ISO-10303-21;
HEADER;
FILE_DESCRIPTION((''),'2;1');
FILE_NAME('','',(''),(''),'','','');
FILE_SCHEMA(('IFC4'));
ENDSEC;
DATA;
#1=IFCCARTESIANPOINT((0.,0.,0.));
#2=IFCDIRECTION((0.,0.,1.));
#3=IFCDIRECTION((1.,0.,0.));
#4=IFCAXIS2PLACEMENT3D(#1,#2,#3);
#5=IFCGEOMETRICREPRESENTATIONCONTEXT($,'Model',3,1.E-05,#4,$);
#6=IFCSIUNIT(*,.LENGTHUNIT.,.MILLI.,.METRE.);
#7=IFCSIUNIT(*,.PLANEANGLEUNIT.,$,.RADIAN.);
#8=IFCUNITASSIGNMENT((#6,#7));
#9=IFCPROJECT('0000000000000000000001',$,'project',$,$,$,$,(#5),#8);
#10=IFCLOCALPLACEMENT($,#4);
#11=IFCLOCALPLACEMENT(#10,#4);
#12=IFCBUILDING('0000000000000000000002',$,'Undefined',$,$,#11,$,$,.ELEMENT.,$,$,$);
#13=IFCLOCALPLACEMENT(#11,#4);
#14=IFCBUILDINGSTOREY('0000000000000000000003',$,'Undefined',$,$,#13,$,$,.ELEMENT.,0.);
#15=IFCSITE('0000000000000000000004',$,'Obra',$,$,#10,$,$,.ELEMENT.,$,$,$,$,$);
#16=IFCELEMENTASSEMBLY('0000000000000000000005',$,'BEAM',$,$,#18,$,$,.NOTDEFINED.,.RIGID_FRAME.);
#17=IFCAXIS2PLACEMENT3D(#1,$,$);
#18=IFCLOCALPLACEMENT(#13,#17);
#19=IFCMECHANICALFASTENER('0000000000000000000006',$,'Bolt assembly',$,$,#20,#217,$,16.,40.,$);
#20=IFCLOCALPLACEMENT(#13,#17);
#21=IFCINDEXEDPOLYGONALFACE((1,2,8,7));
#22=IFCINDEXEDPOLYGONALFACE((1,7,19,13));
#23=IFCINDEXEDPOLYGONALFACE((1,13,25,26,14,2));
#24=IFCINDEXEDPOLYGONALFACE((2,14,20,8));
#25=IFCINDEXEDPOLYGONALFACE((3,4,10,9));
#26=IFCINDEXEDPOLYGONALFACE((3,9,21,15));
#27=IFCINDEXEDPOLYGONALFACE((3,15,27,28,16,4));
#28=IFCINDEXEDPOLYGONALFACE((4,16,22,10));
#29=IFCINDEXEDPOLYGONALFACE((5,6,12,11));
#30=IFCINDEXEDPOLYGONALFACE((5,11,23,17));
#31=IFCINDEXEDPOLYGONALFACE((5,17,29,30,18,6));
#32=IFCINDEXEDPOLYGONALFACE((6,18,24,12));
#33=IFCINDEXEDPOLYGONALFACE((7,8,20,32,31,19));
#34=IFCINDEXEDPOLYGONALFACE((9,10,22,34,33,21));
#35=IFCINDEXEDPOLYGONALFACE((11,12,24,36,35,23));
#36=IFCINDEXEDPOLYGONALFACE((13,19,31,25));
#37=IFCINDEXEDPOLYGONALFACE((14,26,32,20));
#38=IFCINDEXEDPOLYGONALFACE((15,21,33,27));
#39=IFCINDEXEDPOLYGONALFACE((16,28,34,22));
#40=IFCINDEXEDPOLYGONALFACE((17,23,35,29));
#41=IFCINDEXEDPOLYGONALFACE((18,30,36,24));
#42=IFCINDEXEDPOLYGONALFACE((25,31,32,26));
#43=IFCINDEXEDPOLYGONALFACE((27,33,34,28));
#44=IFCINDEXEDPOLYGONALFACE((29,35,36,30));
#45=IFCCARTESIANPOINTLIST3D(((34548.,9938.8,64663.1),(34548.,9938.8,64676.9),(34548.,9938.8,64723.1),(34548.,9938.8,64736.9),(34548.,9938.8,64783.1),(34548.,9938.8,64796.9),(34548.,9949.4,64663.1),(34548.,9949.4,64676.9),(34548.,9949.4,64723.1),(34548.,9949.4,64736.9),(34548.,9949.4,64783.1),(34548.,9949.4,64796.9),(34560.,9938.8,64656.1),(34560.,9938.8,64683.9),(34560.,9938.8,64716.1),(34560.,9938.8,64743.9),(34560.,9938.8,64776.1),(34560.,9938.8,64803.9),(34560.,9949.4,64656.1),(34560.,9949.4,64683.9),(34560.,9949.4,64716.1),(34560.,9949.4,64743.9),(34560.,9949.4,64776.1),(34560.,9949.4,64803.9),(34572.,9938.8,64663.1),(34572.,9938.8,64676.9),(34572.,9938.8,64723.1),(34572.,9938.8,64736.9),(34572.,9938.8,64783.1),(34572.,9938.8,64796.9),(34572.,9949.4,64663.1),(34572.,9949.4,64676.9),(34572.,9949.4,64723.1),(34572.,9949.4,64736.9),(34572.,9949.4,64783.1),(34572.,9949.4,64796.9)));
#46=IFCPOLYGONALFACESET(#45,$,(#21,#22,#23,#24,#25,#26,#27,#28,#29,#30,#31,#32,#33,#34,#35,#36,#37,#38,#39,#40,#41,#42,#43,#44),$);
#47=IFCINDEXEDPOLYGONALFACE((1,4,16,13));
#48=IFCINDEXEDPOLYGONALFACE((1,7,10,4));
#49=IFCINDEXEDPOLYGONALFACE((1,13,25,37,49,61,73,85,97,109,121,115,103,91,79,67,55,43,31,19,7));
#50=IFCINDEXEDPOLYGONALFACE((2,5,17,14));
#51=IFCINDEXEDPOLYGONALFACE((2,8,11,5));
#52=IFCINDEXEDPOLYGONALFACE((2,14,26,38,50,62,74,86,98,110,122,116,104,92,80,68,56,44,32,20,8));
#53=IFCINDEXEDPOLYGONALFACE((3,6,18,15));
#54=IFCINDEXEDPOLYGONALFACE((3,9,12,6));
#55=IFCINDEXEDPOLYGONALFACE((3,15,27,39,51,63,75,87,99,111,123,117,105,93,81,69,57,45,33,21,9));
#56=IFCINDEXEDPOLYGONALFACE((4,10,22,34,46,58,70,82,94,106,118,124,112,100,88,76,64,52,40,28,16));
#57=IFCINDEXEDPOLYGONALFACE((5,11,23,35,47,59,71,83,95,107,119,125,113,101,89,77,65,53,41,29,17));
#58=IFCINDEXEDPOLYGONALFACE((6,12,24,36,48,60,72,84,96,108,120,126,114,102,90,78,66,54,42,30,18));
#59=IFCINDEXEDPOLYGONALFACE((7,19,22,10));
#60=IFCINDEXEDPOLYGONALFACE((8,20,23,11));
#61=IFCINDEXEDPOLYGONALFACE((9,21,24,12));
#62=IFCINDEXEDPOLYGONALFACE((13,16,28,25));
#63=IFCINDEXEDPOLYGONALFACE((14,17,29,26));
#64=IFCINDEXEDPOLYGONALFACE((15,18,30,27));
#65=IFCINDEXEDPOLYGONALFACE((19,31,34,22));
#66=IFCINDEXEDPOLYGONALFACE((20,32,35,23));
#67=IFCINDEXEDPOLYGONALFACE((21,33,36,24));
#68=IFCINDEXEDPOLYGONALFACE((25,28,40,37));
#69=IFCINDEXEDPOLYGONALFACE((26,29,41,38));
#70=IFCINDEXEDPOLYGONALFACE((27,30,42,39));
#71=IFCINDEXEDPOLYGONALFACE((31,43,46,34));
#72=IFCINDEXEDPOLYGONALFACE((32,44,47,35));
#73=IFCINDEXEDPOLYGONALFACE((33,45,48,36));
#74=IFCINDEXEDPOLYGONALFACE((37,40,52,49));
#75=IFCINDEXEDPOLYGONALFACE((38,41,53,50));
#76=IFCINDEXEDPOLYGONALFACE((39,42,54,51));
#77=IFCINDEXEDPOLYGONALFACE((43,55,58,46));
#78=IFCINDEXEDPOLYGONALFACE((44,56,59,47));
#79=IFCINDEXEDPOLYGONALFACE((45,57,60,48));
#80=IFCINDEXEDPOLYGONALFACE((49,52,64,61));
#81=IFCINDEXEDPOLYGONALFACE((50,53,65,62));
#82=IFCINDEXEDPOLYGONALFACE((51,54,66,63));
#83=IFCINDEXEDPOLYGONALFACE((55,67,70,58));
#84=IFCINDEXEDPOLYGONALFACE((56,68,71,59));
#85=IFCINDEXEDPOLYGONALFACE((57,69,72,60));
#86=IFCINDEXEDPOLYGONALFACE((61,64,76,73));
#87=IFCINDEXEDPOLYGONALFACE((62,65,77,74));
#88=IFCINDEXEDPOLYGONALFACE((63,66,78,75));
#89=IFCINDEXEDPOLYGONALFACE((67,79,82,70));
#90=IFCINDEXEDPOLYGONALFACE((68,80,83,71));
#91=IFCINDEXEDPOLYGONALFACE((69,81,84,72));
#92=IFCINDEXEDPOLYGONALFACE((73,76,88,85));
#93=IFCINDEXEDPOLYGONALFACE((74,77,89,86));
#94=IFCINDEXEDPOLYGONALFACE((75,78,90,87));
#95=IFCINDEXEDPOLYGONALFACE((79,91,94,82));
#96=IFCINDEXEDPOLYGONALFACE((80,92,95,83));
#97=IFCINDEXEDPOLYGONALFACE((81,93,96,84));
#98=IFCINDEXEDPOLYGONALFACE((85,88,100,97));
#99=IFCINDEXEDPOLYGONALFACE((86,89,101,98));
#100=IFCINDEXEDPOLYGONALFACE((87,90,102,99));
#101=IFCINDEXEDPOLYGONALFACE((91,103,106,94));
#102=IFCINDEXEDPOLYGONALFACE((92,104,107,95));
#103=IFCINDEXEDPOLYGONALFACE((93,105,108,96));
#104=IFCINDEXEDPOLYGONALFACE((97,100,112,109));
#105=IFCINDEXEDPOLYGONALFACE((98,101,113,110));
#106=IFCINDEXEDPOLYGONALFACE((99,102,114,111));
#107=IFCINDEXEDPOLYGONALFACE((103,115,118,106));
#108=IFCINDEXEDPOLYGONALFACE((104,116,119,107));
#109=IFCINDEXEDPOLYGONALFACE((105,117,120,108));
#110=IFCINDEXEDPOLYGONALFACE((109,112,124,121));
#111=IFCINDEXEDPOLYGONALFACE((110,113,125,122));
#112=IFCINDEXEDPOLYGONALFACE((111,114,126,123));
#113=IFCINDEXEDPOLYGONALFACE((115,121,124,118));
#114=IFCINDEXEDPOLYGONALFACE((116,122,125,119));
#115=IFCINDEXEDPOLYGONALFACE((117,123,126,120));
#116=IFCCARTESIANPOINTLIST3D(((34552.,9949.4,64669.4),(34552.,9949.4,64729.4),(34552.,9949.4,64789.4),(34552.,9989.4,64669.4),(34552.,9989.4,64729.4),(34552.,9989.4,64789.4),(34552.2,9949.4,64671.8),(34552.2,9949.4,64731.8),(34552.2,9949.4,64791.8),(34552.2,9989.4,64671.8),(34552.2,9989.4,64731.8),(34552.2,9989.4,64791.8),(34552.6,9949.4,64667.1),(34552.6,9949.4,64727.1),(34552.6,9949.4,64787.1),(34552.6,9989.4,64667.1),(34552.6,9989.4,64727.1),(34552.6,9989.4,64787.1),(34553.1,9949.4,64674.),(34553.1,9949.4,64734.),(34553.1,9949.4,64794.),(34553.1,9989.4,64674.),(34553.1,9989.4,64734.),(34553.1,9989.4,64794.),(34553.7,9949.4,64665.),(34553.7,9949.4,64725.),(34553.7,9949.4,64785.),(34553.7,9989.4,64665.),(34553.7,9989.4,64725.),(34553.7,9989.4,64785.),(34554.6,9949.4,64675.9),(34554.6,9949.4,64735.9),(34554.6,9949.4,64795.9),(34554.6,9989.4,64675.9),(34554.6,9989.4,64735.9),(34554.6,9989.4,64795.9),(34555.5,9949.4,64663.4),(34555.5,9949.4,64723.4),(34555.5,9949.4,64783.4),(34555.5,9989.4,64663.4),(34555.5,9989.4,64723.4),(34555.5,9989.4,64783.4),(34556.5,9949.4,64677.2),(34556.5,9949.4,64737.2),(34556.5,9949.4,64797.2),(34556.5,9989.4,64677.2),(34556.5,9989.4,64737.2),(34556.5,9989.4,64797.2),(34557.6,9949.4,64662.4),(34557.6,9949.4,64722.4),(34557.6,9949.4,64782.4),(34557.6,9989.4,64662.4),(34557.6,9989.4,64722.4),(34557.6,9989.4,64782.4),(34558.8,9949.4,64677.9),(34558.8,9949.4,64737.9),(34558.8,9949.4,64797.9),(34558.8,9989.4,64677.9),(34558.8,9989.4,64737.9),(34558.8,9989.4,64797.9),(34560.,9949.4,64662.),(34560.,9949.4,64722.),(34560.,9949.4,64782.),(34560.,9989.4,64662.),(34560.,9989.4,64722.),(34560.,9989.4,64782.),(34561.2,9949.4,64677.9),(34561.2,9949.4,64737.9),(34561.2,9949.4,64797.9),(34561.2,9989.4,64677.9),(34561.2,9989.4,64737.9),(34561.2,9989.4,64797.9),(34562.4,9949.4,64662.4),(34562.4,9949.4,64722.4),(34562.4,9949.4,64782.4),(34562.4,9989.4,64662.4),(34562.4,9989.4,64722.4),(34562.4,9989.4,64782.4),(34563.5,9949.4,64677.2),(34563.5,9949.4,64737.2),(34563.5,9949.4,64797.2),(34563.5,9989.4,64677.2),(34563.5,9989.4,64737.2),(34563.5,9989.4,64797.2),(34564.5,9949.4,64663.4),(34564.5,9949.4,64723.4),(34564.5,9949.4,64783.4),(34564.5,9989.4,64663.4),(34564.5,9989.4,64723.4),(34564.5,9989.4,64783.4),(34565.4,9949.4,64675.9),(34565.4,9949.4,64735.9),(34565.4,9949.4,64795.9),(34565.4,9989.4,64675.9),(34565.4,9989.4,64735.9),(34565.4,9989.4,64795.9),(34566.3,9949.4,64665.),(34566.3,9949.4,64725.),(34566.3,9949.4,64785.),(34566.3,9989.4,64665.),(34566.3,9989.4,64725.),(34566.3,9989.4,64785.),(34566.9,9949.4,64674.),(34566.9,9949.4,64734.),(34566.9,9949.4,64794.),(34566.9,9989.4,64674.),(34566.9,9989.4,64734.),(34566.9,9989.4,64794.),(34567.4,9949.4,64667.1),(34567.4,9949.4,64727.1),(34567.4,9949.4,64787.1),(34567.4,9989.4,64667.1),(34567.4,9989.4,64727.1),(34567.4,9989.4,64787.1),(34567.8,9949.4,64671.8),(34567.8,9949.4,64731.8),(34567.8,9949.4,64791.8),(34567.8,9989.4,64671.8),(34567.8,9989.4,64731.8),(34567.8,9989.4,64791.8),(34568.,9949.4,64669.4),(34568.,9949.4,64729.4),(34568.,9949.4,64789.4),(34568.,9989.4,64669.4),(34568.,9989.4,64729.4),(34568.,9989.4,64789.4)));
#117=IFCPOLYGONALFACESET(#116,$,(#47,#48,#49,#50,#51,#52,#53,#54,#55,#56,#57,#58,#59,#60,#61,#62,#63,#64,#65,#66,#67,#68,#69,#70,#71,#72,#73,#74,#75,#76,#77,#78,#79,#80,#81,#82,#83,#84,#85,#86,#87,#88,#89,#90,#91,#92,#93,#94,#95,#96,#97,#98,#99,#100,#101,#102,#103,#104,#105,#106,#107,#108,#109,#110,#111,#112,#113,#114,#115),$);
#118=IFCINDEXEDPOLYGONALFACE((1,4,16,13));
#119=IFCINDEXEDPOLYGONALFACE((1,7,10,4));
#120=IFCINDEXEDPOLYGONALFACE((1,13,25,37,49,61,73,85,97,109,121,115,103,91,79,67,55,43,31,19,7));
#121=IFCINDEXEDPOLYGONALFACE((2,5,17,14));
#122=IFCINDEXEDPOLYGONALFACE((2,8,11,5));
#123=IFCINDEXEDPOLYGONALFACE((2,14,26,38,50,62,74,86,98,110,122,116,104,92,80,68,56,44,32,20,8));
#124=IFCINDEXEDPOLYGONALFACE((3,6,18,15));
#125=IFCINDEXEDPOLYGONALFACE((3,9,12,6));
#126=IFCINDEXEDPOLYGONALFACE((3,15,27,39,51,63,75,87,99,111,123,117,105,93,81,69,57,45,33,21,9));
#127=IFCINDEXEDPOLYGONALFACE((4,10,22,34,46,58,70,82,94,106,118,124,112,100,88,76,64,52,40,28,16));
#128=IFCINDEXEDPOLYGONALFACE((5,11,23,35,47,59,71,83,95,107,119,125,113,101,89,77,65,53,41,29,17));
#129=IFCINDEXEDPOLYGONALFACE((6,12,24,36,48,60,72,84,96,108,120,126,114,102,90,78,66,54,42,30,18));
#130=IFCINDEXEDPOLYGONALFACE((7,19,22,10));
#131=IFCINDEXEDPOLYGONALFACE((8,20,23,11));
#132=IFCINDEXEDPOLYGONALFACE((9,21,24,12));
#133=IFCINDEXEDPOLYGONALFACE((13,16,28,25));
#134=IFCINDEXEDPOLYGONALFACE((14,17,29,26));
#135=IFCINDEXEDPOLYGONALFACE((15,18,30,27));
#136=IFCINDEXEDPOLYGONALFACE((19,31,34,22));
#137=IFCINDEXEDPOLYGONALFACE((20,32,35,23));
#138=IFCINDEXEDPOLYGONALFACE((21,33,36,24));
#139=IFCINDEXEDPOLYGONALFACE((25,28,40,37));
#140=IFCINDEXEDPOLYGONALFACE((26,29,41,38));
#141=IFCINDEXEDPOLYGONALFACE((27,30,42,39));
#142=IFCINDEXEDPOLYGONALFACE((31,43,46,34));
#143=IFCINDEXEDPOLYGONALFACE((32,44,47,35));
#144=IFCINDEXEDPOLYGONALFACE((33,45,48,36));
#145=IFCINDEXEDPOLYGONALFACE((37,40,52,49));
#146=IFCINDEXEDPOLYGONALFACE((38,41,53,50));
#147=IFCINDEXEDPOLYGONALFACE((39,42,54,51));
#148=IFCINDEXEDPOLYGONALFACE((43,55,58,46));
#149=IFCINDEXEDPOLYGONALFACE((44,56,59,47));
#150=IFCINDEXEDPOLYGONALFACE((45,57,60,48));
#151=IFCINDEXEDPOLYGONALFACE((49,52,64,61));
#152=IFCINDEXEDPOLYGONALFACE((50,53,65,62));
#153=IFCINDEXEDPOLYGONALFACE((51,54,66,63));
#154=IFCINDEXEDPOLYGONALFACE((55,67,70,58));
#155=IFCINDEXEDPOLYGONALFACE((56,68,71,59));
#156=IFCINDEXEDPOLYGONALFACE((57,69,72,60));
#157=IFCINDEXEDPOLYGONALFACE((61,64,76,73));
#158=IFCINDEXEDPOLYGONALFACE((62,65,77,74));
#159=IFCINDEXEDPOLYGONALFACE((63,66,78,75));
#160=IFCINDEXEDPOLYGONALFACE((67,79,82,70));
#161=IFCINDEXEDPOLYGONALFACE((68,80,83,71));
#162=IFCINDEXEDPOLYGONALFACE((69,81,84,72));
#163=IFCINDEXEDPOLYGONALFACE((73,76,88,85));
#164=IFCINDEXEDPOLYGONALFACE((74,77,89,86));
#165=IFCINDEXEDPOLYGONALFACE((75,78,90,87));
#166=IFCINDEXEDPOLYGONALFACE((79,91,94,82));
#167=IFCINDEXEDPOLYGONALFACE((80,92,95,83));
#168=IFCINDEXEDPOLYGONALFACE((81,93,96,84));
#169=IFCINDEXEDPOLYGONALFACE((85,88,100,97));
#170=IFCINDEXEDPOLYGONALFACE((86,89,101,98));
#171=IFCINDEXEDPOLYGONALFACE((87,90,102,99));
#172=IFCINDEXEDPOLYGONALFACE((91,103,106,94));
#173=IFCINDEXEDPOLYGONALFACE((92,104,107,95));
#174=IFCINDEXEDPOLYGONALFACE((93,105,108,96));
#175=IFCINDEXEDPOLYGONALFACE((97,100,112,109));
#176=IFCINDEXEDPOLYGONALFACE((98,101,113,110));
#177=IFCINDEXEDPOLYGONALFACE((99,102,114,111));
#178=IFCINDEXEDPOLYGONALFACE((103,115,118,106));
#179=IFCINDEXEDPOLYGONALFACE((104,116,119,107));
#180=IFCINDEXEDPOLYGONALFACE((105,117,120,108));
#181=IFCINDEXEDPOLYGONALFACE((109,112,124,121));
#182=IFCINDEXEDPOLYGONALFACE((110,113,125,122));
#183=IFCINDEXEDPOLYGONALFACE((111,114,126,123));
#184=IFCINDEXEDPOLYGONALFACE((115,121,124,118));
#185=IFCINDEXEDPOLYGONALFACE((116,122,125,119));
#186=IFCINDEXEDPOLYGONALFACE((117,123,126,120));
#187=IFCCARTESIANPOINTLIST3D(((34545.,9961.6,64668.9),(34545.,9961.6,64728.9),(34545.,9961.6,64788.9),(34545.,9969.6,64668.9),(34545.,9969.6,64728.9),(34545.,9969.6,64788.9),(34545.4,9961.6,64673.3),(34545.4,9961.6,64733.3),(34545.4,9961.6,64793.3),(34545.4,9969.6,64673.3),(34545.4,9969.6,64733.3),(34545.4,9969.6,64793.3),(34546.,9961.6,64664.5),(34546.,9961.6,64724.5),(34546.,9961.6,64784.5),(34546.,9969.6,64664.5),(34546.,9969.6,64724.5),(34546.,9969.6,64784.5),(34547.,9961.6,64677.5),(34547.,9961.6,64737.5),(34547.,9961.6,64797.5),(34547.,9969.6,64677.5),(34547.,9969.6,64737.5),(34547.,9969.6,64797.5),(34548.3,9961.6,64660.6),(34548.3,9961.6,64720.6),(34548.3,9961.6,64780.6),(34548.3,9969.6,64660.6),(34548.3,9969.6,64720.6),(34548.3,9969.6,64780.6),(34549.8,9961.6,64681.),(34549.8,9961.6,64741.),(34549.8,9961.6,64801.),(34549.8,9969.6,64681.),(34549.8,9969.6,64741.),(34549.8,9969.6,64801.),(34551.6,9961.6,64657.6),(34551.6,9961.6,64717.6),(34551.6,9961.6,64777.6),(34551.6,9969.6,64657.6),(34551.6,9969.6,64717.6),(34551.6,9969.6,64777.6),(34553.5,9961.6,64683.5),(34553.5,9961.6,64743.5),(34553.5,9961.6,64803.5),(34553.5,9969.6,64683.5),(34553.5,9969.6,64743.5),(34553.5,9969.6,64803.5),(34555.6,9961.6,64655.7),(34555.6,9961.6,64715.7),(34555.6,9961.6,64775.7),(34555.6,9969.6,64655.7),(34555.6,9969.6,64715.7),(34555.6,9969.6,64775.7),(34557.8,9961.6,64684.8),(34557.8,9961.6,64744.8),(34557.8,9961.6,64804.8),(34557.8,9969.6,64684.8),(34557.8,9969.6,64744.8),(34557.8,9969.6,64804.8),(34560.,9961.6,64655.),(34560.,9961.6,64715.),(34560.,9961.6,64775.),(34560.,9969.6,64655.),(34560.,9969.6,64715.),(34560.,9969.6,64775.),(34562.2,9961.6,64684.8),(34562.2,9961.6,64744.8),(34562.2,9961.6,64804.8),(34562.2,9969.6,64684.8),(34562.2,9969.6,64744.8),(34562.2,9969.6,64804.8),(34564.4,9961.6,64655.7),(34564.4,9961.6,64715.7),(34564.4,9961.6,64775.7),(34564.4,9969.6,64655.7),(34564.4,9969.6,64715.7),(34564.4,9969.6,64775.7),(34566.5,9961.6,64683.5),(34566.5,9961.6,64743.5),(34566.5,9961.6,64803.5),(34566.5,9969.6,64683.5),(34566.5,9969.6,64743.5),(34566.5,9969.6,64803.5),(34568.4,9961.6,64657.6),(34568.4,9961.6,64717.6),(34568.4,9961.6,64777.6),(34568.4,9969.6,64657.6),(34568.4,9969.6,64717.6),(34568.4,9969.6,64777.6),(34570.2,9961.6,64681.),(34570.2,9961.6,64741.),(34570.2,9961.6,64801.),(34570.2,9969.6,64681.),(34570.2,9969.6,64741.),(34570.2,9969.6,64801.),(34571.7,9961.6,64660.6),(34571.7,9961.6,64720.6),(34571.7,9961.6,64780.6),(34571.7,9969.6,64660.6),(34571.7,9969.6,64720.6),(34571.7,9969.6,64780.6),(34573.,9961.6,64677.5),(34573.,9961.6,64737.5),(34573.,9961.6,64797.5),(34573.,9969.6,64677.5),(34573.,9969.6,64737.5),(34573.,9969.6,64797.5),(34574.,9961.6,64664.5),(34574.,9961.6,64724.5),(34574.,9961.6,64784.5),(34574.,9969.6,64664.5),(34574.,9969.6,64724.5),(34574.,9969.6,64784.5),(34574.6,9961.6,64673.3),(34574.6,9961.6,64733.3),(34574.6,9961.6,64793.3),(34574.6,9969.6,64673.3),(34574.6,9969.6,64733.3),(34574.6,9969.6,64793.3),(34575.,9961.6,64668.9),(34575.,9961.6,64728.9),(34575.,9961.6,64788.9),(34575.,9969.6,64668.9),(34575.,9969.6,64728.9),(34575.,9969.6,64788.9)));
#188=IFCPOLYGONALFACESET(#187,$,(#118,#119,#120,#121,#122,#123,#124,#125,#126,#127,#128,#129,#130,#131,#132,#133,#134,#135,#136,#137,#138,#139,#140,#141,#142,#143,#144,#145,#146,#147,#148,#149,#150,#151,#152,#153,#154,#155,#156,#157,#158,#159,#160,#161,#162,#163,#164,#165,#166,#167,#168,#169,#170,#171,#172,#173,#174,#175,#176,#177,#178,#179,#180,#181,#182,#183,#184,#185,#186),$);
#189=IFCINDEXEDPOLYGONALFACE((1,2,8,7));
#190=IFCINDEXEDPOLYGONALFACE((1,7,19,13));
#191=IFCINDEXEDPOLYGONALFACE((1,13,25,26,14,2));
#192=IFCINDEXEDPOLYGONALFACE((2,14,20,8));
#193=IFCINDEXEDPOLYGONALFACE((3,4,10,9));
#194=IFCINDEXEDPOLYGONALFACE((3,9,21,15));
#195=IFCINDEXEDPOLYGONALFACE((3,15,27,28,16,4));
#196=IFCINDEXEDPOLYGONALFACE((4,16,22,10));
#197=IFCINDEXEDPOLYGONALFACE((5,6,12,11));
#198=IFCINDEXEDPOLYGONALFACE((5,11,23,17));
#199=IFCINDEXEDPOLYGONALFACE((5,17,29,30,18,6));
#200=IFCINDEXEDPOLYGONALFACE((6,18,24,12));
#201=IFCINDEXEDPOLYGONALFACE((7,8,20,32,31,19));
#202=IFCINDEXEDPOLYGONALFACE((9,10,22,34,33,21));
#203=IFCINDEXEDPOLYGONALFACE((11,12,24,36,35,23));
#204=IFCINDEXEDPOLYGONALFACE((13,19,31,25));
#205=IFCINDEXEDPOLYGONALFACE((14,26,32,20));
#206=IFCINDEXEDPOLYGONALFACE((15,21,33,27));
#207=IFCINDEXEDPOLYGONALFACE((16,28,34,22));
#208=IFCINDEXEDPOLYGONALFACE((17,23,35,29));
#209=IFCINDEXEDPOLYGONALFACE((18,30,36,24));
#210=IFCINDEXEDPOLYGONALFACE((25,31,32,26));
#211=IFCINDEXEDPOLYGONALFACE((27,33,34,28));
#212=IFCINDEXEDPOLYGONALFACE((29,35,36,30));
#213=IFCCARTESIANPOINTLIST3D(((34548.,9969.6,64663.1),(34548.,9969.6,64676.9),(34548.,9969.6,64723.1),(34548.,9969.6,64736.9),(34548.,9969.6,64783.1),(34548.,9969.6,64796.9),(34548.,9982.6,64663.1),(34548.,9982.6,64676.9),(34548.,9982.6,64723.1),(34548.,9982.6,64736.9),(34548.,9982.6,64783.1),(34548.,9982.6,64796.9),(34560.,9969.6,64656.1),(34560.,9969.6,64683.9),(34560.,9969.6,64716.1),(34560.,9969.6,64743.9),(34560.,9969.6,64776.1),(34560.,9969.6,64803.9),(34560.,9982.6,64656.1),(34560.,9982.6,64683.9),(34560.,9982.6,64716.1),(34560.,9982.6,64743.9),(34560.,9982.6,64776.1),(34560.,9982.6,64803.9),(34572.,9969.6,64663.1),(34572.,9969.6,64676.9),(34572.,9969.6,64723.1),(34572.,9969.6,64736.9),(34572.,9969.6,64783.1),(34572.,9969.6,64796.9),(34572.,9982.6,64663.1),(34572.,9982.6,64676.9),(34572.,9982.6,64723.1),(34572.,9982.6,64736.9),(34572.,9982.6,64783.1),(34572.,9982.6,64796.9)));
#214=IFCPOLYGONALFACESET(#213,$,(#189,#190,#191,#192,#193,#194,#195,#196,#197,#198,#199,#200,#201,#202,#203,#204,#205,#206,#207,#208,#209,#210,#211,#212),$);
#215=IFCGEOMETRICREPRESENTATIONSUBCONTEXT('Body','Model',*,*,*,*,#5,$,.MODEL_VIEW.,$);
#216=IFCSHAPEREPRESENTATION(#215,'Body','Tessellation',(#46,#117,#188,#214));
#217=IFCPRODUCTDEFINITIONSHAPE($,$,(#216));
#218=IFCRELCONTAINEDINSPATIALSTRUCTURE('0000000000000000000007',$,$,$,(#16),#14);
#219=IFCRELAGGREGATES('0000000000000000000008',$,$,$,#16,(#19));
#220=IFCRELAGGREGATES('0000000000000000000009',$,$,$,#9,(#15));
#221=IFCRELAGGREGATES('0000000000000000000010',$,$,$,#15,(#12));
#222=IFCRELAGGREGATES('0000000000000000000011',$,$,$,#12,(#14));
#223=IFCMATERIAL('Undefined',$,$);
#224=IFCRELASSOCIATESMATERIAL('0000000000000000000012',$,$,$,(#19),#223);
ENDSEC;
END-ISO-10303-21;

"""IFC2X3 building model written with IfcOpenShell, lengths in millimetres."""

from ifc_helpers import new_model, si_unit, frame, origin_with_axes, origin_2d_with_axis, place, context, subcontext, project, spatial, polyline, circle, outline, extrude, source, transform, mapped, material, element, aggregate, save


model = new_model("IFC2X3")

# Units and contexts
model_context = context("Model", 3, precision=1e-05, world=origin_with_axes())
body_context = subcontext(model_context, "Body", "Model", "MODEL_VIEW")
ifc_project = project(units=[si_unit("LENGTHUNIT", "METRE", prefix="MILLI"), si_unit("PLANEANGLEUNIT", "RADIAN")], contexts=[model_context])

# Site, building, storey
site_placement = place(None, origin_with_axes())
site = spatial("IfcSite", under=ifc_project, at=site_placement, Name="Obra", CompositionType="ELEMENT")
building_placement = place(site_placement, origin_with_axes())
building = spatial("IfcBuilding", under=site, at=building_placement, Name="Undefined", CompositionType="ELEMENT")
storey_placement = place(building_placement, origin_with_axes())
storey = spatial("IfcBuildingStorey", under=building, at=storey_placement, Name="Undefined", CompositionType="ELEMENT", Elevation=0.0)

# Shared definitions
ifc_material = material(Name="Undefined")

# Element assembly
assembly_1_placement = place(storey_placement, origin_with_axes())
assembly_1 = element("IfcElementAssembly", 1, at=assembly_1_placement, inside=storey, Name="BEAM", AssemblyPlace="NOTDEFINED", PredefinedType="RIGID_FRAME")

# Mechanical fastener
shared_shape_1 = source(origin_with_axes(), body_context, "Body", "SweptSolid", [
    extrude(outline(polyline([(13.9, 0.0), (6.9, 12.0), (-6.9, 12.0), (-13.9, 0.0), (-6.9, -12.0), (6.9, -12.0), (13.9, 0.0)])), frame((0.0, -19.7, 0.0), z_axis=(0.0, 1.0, 0.0), x_axis=(1.0, 0.0, 0.0)), (0.0, 0.0, 1.0), 10.6),
    extrude(circle(Radius=8.0, at=origin_2d_with_axis()), frame((0.0, -9.1, 0.0), z_axis=(0.0, 1.0, 0.0), x_axis=(1.0, 0.0, 0.0)), (0.0, 0.0, 1.0), 40.0),
    extrude(circle(Radius=15.0, at=origin_2d_with_axis()), frame((0.0, 3.1, 0.0), z_axis=(0.0, 1.0, 0.0), x_axis=(1.0, 0.0, 0.0)), (0.0, 0.0, 1.0), 8.0),
    extrude(outline(polyline([(13.9, 0.0), (6.9, 12.0), (-6.9, 12.0), (-13.9, 0.0), (-6.9, -12.0), (6.9, -12.0), (13.9, 0.0)])), frame((0.0, 11.1, 0.0), z_axis=(0.0, 1.0, 0.0), x_axis=(1.0, 0.0, 0.0)), (0.0, 0.0, 1.0), 13.0),
])
mechanical_fastener_1_placement = place(assembly_1_placement, frame((34510.0, 9958.5, 64850.0), z_axis=(1.0, 0.0, 0.0), x_axis=(0.0, 0.0, -1.0)))
mechanical_fastener_1 = element("IfcMechanicalFastener", 2, at=mechanical_fastener_1_placement, material=ifc_material, Name="Bolt assembly", NominalDiameter=16.0, NominalLength=40.0, context=body_context, shape_type="MappedRepresentation", body=[
    mapped(shared_shape_1, transform((60.0, 0.0, 50.0))),
    mapped(shared_shape_1, transform((120.0, 0.0, 50.0))),
    mapped(shared_shape_1, transform((180.0, 0.0, 50.0))),
])
aggregate(assembly_1, [mechanical_fastener_1])

save(model, "model.ifc")
